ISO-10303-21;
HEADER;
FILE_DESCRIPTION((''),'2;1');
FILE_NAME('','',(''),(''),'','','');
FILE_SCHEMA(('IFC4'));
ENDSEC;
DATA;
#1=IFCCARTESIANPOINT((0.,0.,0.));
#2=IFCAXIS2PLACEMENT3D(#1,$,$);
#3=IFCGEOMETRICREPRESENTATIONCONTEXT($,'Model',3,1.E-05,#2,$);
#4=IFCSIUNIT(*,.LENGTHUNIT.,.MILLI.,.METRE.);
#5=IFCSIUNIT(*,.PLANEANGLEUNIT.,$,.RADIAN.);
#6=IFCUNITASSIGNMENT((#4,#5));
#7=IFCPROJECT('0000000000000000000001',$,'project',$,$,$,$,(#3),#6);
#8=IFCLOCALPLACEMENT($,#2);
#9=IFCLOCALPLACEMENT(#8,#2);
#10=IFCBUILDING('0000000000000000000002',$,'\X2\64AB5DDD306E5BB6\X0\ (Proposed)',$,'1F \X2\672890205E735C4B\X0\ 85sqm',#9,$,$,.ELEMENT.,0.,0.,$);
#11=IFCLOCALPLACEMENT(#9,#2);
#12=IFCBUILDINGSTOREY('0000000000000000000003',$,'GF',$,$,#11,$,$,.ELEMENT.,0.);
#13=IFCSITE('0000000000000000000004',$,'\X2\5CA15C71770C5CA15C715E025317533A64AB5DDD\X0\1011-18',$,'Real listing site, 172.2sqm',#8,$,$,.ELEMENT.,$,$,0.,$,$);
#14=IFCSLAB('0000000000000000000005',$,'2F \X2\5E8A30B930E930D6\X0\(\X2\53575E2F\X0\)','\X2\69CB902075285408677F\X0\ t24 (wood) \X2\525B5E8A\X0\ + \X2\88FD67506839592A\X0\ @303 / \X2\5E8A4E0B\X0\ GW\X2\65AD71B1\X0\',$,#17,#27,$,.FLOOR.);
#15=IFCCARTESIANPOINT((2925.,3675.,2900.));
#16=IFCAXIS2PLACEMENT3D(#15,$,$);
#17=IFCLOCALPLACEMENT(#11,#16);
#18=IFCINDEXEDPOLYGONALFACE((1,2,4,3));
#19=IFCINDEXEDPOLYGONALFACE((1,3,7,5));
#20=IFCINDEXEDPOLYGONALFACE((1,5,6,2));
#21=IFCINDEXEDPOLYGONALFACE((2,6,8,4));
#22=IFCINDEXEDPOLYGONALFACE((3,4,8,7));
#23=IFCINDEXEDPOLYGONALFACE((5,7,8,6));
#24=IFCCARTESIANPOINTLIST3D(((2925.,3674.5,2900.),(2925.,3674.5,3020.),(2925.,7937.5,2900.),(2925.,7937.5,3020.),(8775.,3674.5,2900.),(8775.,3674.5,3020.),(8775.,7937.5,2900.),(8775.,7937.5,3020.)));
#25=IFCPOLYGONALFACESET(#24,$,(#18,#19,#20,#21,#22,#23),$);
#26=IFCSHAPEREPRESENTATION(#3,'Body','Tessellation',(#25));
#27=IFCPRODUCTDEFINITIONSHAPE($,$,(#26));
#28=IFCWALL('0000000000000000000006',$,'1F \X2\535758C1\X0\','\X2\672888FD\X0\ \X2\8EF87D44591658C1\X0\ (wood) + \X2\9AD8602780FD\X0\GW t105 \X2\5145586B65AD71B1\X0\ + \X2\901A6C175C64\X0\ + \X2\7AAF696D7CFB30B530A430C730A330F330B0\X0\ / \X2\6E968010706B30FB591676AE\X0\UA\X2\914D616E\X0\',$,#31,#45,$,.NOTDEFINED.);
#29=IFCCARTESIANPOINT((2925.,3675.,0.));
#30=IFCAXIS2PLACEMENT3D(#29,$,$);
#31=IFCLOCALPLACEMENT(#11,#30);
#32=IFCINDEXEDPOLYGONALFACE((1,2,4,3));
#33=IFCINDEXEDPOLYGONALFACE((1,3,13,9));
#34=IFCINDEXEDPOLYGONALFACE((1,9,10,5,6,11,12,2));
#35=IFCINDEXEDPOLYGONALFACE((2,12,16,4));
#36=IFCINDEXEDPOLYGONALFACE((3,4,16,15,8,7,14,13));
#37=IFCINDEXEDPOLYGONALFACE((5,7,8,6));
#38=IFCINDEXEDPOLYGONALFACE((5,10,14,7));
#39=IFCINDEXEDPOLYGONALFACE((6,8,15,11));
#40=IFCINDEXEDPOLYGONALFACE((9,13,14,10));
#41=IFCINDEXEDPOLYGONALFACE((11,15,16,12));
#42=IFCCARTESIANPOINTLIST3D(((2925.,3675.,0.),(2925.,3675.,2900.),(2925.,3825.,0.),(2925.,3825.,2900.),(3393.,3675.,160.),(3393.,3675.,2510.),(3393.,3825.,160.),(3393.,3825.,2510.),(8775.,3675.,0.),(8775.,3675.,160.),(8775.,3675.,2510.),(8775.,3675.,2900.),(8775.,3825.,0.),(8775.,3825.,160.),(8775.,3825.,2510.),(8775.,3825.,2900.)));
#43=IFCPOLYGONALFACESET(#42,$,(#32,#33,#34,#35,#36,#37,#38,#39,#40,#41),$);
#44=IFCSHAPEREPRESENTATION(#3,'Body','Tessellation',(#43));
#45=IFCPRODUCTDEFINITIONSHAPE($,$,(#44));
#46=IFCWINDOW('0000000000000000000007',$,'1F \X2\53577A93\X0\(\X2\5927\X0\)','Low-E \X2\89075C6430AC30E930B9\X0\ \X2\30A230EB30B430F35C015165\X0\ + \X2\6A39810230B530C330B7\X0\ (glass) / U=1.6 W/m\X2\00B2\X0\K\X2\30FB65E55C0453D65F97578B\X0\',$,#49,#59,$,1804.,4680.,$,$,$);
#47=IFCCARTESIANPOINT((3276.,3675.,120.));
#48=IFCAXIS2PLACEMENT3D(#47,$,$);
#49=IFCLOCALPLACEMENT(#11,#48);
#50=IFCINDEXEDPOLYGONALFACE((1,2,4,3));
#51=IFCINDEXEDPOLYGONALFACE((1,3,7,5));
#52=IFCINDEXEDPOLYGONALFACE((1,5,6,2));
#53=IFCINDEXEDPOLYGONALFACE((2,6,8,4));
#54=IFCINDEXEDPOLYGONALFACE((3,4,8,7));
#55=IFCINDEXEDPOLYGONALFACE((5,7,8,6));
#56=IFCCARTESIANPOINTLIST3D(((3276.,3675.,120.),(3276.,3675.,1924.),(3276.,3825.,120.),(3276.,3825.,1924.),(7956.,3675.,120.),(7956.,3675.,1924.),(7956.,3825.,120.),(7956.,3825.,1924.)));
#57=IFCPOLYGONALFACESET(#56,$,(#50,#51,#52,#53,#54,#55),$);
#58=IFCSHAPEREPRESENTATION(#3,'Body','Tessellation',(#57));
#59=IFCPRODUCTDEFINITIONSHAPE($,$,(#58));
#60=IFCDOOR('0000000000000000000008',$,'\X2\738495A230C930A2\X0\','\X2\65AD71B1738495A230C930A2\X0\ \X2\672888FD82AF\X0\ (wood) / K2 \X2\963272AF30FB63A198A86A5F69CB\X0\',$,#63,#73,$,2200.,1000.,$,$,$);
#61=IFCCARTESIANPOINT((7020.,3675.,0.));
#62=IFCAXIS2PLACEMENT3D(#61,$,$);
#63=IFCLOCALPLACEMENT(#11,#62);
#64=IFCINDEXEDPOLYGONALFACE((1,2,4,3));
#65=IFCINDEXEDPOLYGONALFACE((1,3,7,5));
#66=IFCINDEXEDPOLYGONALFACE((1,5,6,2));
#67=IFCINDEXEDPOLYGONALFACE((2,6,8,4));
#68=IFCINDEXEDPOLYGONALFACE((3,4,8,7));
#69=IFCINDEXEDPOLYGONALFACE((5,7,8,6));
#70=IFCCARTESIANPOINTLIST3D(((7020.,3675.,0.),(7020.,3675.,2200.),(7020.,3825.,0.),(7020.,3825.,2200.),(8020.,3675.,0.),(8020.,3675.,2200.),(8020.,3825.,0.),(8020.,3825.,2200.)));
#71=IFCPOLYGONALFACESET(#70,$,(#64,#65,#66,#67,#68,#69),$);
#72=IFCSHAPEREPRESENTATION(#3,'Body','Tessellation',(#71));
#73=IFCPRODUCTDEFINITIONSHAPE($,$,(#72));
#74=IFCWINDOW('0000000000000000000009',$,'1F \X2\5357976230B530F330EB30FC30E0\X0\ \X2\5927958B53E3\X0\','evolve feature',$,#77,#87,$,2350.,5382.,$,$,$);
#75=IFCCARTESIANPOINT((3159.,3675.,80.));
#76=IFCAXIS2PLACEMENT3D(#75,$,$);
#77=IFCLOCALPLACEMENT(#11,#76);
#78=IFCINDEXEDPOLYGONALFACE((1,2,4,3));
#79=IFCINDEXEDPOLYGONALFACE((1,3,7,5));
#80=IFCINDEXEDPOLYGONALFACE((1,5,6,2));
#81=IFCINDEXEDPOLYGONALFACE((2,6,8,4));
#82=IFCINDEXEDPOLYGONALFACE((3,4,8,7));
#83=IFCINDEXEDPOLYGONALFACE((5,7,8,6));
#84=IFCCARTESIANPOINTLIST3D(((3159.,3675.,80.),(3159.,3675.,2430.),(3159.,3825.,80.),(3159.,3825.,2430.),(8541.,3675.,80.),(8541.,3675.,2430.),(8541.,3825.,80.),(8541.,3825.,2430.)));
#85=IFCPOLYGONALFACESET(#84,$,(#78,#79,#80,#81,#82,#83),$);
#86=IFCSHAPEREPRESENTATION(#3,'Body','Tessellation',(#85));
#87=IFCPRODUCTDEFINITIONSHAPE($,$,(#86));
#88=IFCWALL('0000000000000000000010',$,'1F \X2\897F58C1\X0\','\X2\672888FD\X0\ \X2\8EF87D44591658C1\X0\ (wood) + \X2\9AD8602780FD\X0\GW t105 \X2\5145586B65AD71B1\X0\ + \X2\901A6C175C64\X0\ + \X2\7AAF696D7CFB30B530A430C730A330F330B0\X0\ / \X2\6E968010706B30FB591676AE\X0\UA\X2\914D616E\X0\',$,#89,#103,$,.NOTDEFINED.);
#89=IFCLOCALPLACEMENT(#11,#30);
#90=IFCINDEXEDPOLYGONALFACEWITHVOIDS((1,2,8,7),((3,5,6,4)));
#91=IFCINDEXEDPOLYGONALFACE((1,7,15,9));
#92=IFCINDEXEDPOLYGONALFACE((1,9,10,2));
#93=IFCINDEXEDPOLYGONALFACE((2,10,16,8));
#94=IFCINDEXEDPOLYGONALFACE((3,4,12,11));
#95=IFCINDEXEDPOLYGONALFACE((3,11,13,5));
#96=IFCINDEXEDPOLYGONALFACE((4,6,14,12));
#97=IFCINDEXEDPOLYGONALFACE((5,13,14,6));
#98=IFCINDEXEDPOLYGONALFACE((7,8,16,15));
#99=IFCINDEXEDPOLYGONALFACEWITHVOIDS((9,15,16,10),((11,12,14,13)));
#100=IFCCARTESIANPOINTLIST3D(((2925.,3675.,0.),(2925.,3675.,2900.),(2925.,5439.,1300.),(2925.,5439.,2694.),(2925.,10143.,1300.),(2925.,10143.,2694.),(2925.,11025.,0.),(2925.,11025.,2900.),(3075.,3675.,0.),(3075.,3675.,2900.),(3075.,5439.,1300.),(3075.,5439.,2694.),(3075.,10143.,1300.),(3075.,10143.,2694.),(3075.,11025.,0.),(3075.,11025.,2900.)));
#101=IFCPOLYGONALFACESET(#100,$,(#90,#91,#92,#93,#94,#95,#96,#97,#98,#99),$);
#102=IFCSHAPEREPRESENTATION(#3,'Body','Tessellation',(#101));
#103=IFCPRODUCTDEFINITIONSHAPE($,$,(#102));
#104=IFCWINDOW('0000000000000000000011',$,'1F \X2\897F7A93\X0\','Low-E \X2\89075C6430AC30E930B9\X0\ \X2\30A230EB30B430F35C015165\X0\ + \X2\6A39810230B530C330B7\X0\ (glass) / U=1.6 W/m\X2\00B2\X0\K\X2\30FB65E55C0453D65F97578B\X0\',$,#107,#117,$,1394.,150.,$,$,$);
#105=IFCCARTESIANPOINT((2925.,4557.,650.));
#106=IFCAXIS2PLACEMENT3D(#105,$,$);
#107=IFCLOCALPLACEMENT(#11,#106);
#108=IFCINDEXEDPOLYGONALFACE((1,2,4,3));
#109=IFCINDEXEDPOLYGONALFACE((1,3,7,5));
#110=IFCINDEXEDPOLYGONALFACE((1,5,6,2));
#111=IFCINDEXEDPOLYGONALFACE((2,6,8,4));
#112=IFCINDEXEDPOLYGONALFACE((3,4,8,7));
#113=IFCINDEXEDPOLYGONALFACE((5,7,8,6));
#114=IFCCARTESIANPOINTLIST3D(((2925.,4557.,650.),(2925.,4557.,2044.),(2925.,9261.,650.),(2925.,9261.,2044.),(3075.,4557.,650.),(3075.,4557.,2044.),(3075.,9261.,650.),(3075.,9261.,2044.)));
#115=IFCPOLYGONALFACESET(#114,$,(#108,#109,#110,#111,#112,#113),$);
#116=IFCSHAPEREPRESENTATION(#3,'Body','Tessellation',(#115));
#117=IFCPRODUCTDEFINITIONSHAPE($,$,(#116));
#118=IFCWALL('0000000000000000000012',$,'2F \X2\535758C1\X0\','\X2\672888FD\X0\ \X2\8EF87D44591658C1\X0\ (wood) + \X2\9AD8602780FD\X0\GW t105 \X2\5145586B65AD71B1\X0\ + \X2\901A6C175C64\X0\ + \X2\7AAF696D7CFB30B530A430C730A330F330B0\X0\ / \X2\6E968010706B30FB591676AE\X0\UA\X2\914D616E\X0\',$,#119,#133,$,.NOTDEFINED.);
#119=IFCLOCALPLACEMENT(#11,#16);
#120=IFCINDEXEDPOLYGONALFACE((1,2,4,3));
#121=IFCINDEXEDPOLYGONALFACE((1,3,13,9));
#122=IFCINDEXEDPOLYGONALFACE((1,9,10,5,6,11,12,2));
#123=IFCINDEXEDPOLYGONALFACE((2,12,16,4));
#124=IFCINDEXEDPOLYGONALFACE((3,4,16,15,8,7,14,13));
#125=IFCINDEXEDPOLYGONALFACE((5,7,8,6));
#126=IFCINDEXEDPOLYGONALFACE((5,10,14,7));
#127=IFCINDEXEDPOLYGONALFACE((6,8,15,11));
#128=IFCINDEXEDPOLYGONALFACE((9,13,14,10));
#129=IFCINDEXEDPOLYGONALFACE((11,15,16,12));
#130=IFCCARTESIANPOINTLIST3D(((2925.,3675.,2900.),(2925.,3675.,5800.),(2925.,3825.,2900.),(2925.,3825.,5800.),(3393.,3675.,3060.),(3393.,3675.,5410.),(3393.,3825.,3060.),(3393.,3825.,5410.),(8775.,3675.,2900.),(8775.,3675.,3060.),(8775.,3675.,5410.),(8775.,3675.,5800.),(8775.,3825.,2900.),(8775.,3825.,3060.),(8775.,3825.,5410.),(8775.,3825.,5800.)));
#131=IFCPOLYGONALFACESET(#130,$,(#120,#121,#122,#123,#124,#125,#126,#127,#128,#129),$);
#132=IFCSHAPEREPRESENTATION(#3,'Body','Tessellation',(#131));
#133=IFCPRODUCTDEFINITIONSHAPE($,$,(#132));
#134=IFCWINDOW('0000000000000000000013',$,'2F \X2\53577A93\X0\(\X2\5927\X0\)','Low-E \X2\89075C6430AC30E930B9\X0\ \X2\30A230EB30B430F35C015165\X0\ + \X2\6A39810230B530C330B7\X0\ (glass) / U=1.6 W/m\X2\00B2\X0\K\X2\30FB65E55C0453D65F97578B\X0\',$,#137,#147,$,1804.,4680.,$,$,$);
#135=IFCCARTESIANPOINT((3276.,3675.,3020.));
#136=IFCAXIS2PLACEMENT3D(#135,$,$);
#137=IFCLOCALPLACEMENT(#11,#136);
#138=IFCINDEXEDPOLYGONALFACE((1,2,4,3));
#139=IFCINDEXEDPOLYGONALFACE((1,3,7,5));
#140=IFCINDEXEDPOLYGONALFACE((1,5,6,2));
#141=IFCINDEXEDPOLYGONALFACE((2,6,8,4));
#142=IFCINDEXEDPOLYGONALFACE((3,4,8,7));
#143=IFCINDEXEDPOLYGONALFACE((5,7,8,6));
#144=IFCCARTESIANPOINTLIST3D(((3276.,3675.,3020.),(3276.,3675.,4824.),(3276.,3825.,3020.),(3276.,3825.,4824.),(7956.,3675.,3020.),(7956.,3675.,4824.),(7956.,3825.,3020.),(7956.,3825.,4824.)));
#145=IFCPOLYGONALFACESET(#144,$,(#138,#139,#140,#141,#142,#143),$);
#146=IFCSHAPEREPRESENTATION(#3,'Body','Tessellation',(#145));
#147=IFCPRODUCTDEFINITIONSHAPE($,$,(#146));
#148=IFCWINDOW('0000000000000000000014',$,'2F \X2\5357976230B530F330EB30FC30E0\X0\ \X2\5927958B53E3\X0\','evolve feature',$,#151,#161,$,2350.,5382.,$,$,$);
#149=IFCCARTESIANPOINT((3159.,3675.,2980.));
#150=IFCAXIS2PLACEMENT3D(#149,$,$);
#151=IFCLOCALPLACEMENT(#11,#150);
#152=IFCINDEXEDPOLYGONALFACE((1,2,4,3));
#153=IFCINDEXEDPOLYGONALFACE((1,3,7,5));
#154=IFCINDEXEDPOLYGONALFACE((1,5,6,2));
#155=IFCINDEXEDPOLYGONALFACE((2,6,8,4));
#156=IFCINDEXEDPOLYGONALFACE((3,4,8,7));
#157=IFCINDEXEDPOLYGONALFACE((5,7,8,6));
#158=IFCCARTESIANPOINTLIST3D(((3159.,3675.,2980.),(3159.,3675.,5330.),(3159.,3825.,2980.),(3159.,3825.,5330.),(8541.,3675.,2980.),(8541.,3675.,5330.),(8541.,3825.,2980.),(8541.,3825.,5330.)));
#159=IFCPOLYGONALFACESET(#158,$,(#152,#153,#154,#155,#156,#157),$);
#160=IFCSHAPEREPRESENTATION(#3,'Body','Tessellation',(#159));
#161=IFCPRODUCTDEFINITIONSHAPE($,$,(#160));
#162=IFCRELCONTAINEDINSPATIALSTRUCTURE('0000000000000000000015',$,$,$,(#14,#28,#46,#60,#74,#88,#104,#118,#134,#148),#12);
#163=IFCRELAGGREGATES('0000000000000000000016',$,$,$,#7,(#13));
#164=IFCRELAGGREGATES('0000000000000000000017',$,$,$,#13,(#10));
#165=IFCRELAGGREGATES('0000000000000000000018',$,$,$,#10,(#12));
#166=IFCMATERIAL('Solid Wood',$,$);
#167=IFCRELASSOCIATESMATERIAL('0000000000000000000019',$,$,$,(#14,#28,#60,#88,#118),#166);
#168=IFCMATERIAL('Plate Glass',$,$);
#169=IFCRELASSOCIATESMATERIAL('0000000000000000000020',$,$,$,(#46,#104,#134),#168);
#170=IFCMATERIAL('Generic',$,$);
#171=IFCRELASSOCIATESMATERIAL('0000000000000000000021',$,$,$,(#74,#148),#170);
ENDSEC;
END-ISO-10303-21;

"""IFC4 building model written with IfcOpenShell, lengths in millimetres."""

from ifc_helpers import new_model, si_unit, frame, frame_2d, origin, place, context, project, spatial, rectangle, extrude, material, element, fill, save


model = new_model("IFC4")

# Units and contexts
model_context = context("Model", 3, precision=1e-05, world=origin())
ifc_project = project(units=[si_unit("LENGTHUNIT", "METRE", prefix="MILLI"), si_unit("PLANEANGLEUNIT", "RADIAN")], contexts=[model_context])

# Site, building, storey
site_placement = place(None, origin())
site = spatial("IfcSite", under=ifc_project, at=site_placement, Name="岡山県岡山市北区撫川1011-18", ObjectType="Real listing site, 172.2sqm", CompositionType="ELEMENT", RefElevation=0.0)
building_placement = place(site_placement, origin())
building = spatial("IfcBuilding", under=site, at=building_placement, Name="撫川の家 (Proposed)", ObjectType="1F 木造平屋 85sqm", CompositionType="ELEMENT", ElevationOfRefHeight=0.0, ElevationOfTerrain=0.0)
storey_placement = place(building_placement, origin())
storey = spatial("IfcBuildingStorey", under=building, at=storey_placement, Name="GF", CompositionType="ELEMENT", Elevation=0.0)

# Slab
ifc_material_1 = material(Name="Solid Wood")
slab_1_placement = place(storey_placement, frame((2925.0, 3675.0, 2900.0)))
element("IfcSlab", 1, at=slab_1_placement, inside=storey, material=ifc_material_1, Name="2F 床スラブ(南帯)", Description="構造用合板 t24 (wood) 剛床 + 製材根太 @303 / 床下 GW断熱", PredefinedType="FLOOR", context=model_context, shape_type="SweptSolid", body=[
    extrude(rectangle(XDim=5850.0, YDim=4263.0, at=frame_2d((2925.0, 2131.0))), frame((2925.0, 3675.0, 2900.0)), (0.0, 0.0, 1.0), 120.0),
])
ifc_material_2 = material(Name="Generic")

# Wall, openings, windows, door
wall_1_placement = place(storey_placement, frame((2925.0, 3675.0, 0.0)))
wall_1 = element("IfcWall", 2, at=wall_1_placement, inside=storey, material=ifc_material_1, Name="1F 南壁", Description="木製 軸組外壁 (wood) + 高性能GW t105 充填断熱 + 通気層 + 窯業系サイディング / 準耐火・外皮UA配慮", PredefinedType="NOTDEFINED", context=model_context, shape_type="SweptSolid", body=[
    extrude(rectangle(XDim=5850.0, YDim=150.0, at=frame_2d((2925.0, 75.0))), frame((2925.0, 3675.0, 0.0)), (0.0, 0.0, 1.0), 2900.0),
])
opening_1_placement = place(storey_placement, frame((3276.0, 3675.0, 120.0)))
opening_1 = element("IfcOpeningElement", 3, at=opening_1_placement, cuts=wall_1, PredefinedType="NOTDEFINED", context=model_context, shape_type="SweptSolid", body=[
    extrude(rectangle(XDim=4680.0, YDim=150.0, at=frame_2d((2340.0, 75.0))), frame((3276.0, 3675.0, 120.0)), (0.0, 0.0, 1.0), 1804.0),
])
opening_2_placement = place(storey_placement, frame((7020.0, 3675.0, 0.0)))
opening_2 = element("IfcOpeningElement", 4, at=opening_2_placement, cuts=wall_1, PredefinedType="NOTDEFINED", context=model_context, shape_type="SweptSolid", body=[
    extrude(rectangle(XDim=1000.0, YDim=150.0, at=frame_2d((500.0, 75.0))), frame((7020.0, 3675.0, 0.0)), (0.0, 0.0, 1.0), 2200.0),
])
opening_3_placement = place(storey_placement, frame((3159.0, 3675.0, 80.0)))
opening_3 = element("IfcOpeningElement", 5, at=opening_3_placement, cuts=wall_1, PredefinedType="NOTDEFINED", context=model_context, shape_type="SweptSolid", body=[
    extrude(rectangle(XDim=5382.0, YDim=150.0, at=frame_2d((2691.0, 75.0))), frame((3159.0, 3675.0, 80.0)), (0.0, 0.0, 1.0), 2350.0),
])
ifc_material_3 = material(Name="Plate Glass")
window_1_placement = place(storey_placement, frame((3276.0, 3675.0, 120.0)))
window_1 = element("IfcWindow", 6, at=window_1_placement, inside=storey, material=ifc_material_3, Name="1F 南窓(大)", Description="Low-E 複層ガラス アルゴン封入 + 樹脂サッシ (glass) / U=1.6 W/m²K・日射取得型", OverallHeight=1804.0, OverallWidth=4680.0, context=model_context, shape_type="SweptSolid", body=[
    extrude(rectangle(XDim=4680.0, YDim=150.0, at=frame_2d((2340.0, 75.0))), frame((3276.0, 3675.0, 120.0)), (0.0, 0.0, 1.0), 1804.0),
])
fill(opening_1, window_1)
door_placement = place(storey_placement, frame((7020.0, 3675.0, 0.0)))
door = element("IfcDoor", 7, at=door_placement, inside=storey, material=ifc_material_1, Name="玄関ドア", Description="断熱玄関ドア 木製芯 (wood) / K2 防犯・採風機構", OverallHeight=2200.0, OverallWidth=1000.0, context=model_context, shape_type="SweptSolid", body=[
    extrude(rectangle(XDim=1000.0, YDim=150.0, at=frame_2d((500.0, 75.0))), frame((7020.0, 3675.0, 0.0)), (0.0, 0.0, 1.0), 2200.0),
])
fill(opening_2, door)
window_2_placement = place(storey_placement, frame((3159.0, 3675.0, 80.0)))
window_2 = element("IfcWindow", 8, at=window_2_placement, inside=storey, material=ifc_material_2, Name="1F 南面サンルーム 大開口", Description="evolve feature", OverallHeight=2350.0, OverallWidth=5382.0, context=model_context, shape_type="SweptSolid", body=[
    extrude(rectangle(XDim=5382.0, YDim=150.0, at=frame_2d((2691.0, 75.0))), frame((3159.0, 3675.0, 80.0)), (0.0, 0.0, 1.0), 2350.0),
])
fill(opening_3, window_2)

# Wall, opening, window
wall_2_placement = place(storey_placement, frame((2925.0, 3675.0, 0.0)))
wall_2 = element("IfcWall", 9, at=wall_2_placement, inside=storey, material=ifc_material_1, Name="1F 西壁", Description="木製 軸組外壁 (wood) + 高性能GW t105 充填断熱 + 通気層 + 窯業系サイディング / 準耐火・外皮UA配慮", PredefinedType="NOTDEFINED", context=model_context, shape_type="SweptSolid", body=[
    extrude(rectangle(XDim=150.0, YDim=7350.0, at=frame_2d((75.0, 3675.0))), frame((2925.0, 3675.0, 0.0)), (0.0, 0.0, 1.0), 2900.0),
])
opening_4_placement = place(storey_placement, frame((2925.0, 4557.0, 650.0)))
opening_4 = element("IfcOpeningElement", 10, at=opening_4_placement, cuts=wall_2, PredefinedType="NOTDEFINED", context=model_context, shape_type="SweptSolid", body=[
    extrude(rectangle(XDim=150.0, YDim=4704.0, at=frame_2d((75.0, 2352.0))), frame((2925.0, 4557.0, 650.0)), (0.0, 0.0, 1.0), 1394.0),
])
window_3_placement = place(storey_placement, frame((2925.0, 4557.0, 650.0)))
window_3 = element("IfcWindow", 11, at=window_3_placement, inside=storey, material=ifc_material_3, Name="1F 西窓", Description="Low-E 複層ガラス アルゴン封入 + 樹脂サッシ (glass) / U=1.6 W/m²K・日射取得型", OverallHeight=1394.0, OverallWidth=150.0, context=model_context, shape_type="SweptSolid", body=[
    extrude(rectangle(XDim=150.0, YDim=4704.0, at=frame_2d((75.0, 2352.0))), frame((2925.0, 4557.0, 650.0)), (0.0, 0.0, 1.0), 1394.0),
])
fill(opening_4, window_3)

# Wall, openings, windows
wall_3_placement = place(storey_placement, frame((2925.0, 3675.0, 2900.0)))
wall_3 = element("IfcWall", 12, at=wall_3_placement, inside=storey, material=ifc_material_1, Name="2F 南壁", Description="木製 軸組外壁 (wood) + 高性能GW t105 充填断熱 + 通気層 + 窯業系サイディング / 準耐火・外皮UA配慮", PredefinedType="NOTDEFINED", context=model_context, shape_type="SweptSolid", body=[
    extrude(rectangle(XDim=5850.0, YDim=150.0, at=frame_2d((2925.0, 75.0))), frame((2925.0, 3675.0, 2900.0)), (0.0, 0.0, 1.0), 2900.0),
])
opening_5_placement = place(storey_placement, frame((3276.0, 3675.0, 3020.0)))
opening_5 = element("IfcOpeningElement", 13, at=opening_5_placement, cuts=wall_3, PredefinedType="NOTDEFINED", context=model_context, shape_type="SweptSolid", body=[
    extrude(rectangle(XDim=4680.0, YDim=150.0, at=frame_2d((2340.0, 75.0))), frame((3276.0, 3675.0, 3020.0)), (0.0, 0.0, 1.0), 1804.0),
])
opening_6_placement = place(storey_placement, frame((3159.0, 3675.0, 2980.0)))
opening_6 = element("IfcOpeningElement", 14, at=opening_6_placement, cuts=wall_3, PredefinedType="NOTDEFINED", context=model_context, shape_type="SweptSolid", body=[
    extrude(rectangle(XDim=5382.0, YDim=150.0, at=frame_2d((2691.0, 75.0))), frame((3159.0, 3675.0, 2980.0)), (0.0, 0.0, 1.0), 2350.0),
])
window_4_placement = place(storey_placement, frame((3276.0, 3675.0, 3020.0)))
window_4 = element("IfcWindow", 15, at=window_4_placement, inside=storey, material=ifc_material_3, Name="2F 南窓(大)", Description="Low-E 複層ガラス アルゴン封入 + 樹脂サッシ (glass) / U=1.6 W/m²K・日射取得型", OverallHeight=1804.0, OverallWidth=4680.0, context=model_context, shape_type="SweptSolid", body=[
    extrude(rectangle(XDim=4680.0, YDim=150.0, at=frame_2d((2340.0, 75.0))), frame((3276.0, 3675.0, 3020.0)), (0.0, 0.0, 1.0), 1804.0),
])
fill(opening_5, window_4)
window_5_placement = place(storey_placement, frame((3159.0, 3675.0, 2980.0)))
window_5 = element("IfcWindow", 16, at=window_5_placement, inside=storey, material=ifc_material_2, Name="2F 南面サンルーム 大開口", Description="evolve feature", OverallHeight=2350.0, OverallWidth=5382.0, context=model_context, shape_type="SweptSolid", body=[
    extrude(rectangle(XDim=5382.0, YDim=150.0, at=frame_2d((2691.0, 75.0))), frame((3159.0, 3675.0, 2980.0)), (0.0, 0.0, 1.0), 2350.0),
])
fill(opening_6, window_5)

save(model, "model.ifc")
